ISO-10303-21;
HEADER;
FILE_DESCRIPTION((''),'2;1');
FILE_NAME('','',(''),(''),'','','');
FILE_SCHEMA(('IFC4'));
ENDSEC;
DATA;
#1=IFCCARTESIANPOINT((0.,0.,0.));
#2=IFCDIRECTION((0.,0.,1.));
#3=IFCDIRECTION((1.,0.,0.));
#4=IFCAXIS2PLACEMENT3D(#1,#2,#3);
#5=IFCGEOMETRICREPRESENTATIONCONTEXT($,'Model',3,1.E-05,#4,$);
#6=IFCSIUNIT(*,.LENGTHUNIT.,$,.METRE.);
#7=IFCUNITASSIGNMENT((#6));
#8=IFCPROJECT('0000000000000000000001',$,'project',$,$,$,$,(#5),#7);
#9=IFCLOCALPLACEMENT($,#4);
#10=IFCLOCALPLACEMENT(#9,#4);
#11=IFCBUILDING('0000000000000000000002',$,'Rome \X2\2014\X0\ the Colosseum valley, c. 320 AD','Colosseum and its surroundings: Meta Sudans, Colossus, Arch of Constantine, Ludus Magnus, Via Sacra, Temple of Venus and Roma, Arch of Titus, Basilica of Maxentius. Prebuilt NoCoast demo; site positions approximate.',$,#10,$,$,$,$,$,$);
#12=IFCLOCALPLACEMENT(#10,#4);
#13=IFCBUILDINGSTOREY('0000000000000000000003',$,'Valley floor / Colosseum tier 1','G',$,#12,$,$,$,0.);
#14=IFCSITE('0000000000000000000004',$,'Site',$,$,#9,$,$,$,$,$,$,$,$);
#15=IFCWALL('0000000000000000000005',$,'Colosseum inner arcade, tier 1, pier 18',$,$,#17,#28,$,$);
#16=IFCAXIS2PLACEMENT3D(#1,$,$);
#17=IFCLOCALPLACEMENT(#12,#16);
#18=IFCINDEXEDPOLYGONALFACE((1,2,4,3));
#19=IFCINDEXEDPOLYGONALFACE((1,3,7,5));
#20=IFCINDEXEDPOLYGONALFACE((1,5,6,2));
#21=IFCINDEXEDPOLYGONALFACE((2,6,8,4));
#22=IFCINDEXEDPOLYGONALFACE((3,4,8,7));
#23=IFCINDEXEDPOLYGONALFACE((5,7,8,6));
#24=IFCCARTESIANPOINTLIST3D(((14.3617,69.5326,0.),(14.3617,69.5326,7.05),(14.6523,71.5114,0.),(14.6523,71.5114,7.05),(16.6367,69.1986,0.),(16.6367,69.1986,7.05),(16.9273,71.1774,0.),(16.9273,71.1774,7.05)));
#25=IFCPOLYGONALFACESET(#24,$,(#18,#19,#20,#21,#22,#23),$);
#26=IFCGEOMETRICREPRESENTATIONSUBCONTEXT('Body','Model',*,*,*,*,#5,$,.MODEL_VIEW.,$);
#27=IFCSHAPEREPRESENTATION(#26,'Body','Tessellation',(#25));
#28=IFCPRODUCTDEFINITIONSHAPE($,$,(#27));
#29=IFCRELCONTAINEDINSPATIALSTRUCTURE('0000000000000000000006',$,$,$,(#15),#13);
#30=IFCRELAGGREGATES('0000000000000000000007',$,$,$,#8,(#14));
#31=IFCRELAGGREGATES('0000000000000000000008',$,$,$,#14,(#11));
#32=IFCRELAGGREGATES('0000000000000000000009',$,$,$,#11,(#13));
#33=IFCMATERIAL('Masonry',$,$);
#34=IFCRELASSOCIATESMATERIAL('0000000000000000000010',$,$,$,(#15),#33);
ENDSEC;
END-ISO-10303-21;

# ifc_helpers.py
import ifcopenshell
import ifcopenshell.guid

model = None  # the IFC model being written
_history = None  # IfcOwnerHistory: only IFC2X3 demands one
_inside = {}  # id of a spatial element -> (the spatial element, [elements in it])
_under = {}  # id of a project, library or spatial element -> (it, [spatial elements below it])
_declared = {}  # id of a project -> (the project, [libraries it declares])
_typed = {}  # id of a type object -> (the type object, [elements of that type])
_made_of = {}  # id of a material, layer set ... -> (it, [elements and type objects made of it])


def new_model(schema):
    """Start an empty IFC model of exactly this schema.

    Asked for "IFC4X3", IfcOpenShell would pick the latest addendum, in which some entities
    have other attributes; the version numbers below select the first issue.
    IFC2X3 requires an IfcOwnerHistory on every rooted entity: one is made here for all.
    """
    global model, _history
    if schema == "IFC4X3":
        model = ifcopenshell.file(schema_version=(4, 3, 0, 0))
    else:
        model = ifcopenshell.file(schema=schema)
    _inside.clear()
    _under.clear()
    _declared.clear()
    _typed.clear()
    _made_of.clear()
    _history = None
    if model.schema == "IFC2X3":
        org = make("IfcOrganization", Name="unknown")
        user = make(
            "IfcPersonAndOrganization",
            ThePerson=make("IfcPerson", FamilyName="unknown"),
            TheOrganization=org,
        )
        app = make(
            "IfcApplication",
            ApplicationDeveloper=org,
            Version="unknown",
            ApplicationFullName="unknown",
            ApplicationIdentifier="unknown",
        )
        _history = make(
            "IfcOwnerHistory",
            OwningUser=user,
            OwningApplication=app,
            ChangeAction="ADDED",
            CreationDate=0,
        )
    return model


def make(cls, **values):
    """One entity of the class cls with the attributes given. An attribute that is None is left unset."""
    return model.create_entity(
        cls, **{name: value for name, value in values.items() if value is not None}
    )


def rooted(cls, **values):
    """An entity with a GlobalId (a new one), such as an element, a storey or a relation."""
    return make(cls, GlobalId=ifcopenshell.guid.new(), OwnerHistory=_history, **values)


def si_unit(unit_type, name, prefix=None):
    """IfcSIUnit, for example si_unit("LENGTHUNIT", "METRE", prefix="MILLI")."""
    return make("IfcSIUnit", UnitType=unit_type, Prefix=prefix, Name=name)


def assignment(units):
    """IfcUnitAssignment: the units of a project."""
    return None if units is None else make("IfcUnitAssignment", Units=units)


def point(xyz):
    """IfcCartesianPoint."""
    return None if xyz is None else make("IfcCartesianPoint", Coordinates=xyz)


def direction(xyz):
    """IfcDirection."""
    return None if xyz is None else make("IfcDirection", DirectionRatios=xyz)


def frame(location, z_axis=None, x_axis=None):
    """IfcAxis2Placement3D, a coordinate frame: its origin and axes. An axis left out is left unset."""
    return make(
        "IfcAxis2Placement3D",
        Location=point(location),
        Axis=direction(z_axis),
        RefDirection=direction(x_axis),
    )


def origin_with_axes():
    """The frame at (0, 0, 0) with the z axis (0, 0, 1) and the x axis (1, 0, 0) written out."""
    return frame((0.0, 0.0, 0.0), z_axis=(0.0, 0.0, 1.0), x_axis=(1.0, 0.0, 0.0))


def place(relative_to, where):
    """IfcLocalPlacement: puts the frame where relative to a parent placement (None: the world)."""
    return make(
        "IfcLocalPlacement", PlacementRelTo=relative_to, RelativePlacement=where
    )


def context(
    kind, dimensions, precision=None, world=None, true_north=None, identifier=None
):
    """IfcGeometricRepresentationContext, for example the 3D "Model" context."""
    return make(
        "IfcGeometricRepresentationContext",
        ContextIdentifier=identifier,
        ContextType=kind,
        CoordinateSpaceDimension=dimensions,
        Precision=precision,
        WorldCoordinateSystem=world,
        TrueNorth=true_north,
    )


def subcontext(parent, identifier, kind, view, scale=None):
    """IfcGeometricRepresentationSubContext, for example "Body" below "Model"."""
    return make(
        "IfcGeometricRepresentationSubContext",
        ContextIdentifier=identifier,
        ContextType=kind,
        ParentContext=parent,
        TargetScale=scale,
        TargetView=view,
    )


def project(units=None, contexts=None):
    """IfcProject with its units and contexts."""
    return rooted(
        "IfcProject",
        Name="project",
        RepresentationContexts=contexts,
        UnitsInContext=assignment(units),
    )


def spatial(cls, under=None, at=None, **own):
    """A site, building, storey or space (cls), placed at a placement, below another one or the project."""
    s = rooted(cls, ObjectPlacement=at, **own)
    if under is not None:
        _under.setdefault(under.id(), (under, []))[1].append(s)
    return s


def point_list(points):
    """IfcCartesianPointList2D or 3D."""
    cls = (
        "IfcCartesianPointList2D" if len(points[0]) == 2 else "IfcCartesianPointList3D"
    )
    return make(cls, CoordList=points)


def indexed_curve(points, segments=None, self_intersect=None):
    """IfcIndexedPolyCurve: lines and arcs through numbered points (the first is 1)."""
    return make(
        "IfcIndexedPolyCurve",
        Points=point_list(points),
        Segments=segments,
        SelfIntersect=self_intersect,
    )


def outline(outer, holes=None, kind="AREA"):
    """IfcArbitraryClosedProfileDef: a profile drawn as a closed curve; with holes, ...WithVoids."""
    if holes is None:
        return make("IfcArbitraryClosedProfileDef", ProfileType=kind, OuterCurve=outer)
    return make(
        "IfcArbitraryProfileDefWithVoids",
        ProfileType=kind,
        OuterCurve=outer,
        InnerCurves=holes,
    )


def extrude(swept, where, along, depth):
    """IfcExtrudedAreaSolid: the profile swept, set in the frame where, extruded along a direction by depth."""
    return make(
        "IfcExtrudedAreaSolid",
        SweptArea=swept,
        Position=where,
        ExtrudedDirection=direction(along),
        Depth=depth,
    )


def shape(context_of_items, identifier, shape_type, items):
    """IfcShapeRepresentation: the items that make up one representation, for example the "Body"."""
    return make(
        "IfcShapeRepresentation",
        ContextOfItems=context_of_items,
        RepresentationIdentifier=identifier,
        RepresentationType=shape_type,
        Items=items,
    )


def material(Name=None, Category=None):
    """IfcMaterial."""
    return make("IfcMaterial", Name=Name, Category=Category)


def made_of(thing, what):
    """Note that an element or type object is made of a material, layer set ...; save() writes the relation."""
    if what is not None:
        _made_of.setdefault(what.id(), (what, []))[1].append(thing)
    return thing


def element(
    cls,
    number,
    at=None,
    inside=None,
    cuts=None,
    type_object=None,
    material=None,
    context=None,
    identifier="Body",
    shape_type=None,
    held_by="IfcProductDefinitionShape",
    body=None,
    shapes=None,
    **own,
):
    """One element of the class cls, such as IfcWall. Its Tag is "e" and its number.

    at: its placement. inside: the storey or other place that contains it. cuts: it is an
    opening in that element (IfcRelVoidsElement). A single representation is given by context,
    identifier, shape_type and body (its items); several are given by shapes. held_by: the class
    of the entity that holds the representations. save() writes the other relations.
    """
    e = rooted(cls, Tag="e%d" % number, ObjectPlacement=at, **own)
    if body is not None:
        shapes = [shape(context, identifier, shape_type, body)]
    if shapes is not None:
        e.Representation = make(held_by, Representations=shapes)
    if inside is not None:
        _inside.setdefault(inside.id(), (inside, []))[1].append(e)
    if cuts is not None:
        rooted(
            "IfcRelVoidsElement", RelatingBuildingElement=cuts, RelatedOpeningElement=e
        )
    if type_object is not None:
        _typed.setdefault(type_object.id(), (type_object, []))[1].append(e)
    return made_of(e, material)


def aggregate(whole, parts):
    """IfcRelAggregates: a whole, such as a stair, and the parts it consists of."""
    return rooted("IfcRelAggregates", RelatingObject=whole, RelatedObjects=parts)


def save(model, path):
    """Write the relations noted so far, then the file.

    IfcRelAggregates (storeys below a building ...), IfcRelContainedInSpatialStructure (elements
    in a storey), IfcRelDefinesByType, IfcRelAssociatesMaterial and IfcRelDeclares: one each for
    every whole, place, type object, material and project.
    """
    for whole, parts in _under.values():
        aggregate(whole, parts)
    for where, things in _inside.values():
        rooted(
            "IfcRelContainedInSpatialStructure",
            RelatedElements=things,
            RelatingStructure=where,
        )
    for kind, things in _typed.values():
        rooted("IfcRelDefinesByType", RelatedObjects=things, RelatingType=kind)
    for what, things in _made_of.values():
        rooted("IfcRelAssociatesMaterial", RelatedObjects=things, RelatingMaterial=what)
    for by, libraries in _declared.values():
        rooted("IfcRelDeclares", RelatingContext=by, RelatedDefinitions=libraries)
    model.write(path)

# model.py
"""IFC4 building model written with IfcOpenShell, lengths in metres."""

from ifc_helpers import new_model, si_unit, frame, origin_with_axes, place, context, subcontext, project, spatial, indexed_curve, outline, extrude, material, element, save


model = new_model("IFC4")

# Units and contexts
model_context = context("Model", 3, precision=1e-05, world=origin_with_axes())
body_context = subcontext(model_context, "Body", "Model", "MODEL_VIEW")
ifc_project = project(units=[si_unit("LENGTHUNIT", "METRE")], contexts=[model_context])

# Site, building, storey
site_placement = place(None, origin_with_axes())
site = spatial("IfcSite", under=ifc_project, at=site_placement, Name="Site")
building_placement = place(site_placement, origin_with_axes())
building = spatial("IfcBuilding", under=site, at=building_placement, Name="Rome — the Colosseum valley, c. 320 AD", Description="Colosseum and its surroundings: Meta Sudans, Colossus, Arch of Constantine, Ludus Magnus, Via Sacra, Temple of Venus and Roma, Arch of Titus, Basilica of Maxentius. Prebuilt NoCoast demo; site positions approximate.")
storey_placement = place(building_placement, origin_with_axes())
storey = spatial("IfcBuildingStorey", under=building, at=storey_placement, Name="Valley floor / Colosseum tier 1", Description="G", Elevation=0.0)

# Wall
ifc_material = material(Name="Masonry")
wall_1_placement = place(storey_placement, frame((16.782, 70.188, 0.0), z_axis=(0.0, 0.0, 1.0), x_axis=(-0.989394, 0.145256, 0.0)))
element("IfcWall", 1, at=wall_1_placement, inside=storey, material=ifc_material, Name="Colosseum inner arcade, tier 1, pier 18", context=body_context, shape_type="SweptSolid", body=[
    extrude(outline(indexed_curve([(0.0, 0.0), (0.0, 2.0), (2.2994, 2.0), (2.2994, 0.0), (0.0, 0.0)], self_intersect=False)), frame((0.0, -1.0, 0.0), z_axis=(0.0, 0.0, 1.0), x_axis=(1.0, 0.0, 0.0)), (0.0, 0.0, 1.0), 7.05),
])

save(model, "model.ifc")
